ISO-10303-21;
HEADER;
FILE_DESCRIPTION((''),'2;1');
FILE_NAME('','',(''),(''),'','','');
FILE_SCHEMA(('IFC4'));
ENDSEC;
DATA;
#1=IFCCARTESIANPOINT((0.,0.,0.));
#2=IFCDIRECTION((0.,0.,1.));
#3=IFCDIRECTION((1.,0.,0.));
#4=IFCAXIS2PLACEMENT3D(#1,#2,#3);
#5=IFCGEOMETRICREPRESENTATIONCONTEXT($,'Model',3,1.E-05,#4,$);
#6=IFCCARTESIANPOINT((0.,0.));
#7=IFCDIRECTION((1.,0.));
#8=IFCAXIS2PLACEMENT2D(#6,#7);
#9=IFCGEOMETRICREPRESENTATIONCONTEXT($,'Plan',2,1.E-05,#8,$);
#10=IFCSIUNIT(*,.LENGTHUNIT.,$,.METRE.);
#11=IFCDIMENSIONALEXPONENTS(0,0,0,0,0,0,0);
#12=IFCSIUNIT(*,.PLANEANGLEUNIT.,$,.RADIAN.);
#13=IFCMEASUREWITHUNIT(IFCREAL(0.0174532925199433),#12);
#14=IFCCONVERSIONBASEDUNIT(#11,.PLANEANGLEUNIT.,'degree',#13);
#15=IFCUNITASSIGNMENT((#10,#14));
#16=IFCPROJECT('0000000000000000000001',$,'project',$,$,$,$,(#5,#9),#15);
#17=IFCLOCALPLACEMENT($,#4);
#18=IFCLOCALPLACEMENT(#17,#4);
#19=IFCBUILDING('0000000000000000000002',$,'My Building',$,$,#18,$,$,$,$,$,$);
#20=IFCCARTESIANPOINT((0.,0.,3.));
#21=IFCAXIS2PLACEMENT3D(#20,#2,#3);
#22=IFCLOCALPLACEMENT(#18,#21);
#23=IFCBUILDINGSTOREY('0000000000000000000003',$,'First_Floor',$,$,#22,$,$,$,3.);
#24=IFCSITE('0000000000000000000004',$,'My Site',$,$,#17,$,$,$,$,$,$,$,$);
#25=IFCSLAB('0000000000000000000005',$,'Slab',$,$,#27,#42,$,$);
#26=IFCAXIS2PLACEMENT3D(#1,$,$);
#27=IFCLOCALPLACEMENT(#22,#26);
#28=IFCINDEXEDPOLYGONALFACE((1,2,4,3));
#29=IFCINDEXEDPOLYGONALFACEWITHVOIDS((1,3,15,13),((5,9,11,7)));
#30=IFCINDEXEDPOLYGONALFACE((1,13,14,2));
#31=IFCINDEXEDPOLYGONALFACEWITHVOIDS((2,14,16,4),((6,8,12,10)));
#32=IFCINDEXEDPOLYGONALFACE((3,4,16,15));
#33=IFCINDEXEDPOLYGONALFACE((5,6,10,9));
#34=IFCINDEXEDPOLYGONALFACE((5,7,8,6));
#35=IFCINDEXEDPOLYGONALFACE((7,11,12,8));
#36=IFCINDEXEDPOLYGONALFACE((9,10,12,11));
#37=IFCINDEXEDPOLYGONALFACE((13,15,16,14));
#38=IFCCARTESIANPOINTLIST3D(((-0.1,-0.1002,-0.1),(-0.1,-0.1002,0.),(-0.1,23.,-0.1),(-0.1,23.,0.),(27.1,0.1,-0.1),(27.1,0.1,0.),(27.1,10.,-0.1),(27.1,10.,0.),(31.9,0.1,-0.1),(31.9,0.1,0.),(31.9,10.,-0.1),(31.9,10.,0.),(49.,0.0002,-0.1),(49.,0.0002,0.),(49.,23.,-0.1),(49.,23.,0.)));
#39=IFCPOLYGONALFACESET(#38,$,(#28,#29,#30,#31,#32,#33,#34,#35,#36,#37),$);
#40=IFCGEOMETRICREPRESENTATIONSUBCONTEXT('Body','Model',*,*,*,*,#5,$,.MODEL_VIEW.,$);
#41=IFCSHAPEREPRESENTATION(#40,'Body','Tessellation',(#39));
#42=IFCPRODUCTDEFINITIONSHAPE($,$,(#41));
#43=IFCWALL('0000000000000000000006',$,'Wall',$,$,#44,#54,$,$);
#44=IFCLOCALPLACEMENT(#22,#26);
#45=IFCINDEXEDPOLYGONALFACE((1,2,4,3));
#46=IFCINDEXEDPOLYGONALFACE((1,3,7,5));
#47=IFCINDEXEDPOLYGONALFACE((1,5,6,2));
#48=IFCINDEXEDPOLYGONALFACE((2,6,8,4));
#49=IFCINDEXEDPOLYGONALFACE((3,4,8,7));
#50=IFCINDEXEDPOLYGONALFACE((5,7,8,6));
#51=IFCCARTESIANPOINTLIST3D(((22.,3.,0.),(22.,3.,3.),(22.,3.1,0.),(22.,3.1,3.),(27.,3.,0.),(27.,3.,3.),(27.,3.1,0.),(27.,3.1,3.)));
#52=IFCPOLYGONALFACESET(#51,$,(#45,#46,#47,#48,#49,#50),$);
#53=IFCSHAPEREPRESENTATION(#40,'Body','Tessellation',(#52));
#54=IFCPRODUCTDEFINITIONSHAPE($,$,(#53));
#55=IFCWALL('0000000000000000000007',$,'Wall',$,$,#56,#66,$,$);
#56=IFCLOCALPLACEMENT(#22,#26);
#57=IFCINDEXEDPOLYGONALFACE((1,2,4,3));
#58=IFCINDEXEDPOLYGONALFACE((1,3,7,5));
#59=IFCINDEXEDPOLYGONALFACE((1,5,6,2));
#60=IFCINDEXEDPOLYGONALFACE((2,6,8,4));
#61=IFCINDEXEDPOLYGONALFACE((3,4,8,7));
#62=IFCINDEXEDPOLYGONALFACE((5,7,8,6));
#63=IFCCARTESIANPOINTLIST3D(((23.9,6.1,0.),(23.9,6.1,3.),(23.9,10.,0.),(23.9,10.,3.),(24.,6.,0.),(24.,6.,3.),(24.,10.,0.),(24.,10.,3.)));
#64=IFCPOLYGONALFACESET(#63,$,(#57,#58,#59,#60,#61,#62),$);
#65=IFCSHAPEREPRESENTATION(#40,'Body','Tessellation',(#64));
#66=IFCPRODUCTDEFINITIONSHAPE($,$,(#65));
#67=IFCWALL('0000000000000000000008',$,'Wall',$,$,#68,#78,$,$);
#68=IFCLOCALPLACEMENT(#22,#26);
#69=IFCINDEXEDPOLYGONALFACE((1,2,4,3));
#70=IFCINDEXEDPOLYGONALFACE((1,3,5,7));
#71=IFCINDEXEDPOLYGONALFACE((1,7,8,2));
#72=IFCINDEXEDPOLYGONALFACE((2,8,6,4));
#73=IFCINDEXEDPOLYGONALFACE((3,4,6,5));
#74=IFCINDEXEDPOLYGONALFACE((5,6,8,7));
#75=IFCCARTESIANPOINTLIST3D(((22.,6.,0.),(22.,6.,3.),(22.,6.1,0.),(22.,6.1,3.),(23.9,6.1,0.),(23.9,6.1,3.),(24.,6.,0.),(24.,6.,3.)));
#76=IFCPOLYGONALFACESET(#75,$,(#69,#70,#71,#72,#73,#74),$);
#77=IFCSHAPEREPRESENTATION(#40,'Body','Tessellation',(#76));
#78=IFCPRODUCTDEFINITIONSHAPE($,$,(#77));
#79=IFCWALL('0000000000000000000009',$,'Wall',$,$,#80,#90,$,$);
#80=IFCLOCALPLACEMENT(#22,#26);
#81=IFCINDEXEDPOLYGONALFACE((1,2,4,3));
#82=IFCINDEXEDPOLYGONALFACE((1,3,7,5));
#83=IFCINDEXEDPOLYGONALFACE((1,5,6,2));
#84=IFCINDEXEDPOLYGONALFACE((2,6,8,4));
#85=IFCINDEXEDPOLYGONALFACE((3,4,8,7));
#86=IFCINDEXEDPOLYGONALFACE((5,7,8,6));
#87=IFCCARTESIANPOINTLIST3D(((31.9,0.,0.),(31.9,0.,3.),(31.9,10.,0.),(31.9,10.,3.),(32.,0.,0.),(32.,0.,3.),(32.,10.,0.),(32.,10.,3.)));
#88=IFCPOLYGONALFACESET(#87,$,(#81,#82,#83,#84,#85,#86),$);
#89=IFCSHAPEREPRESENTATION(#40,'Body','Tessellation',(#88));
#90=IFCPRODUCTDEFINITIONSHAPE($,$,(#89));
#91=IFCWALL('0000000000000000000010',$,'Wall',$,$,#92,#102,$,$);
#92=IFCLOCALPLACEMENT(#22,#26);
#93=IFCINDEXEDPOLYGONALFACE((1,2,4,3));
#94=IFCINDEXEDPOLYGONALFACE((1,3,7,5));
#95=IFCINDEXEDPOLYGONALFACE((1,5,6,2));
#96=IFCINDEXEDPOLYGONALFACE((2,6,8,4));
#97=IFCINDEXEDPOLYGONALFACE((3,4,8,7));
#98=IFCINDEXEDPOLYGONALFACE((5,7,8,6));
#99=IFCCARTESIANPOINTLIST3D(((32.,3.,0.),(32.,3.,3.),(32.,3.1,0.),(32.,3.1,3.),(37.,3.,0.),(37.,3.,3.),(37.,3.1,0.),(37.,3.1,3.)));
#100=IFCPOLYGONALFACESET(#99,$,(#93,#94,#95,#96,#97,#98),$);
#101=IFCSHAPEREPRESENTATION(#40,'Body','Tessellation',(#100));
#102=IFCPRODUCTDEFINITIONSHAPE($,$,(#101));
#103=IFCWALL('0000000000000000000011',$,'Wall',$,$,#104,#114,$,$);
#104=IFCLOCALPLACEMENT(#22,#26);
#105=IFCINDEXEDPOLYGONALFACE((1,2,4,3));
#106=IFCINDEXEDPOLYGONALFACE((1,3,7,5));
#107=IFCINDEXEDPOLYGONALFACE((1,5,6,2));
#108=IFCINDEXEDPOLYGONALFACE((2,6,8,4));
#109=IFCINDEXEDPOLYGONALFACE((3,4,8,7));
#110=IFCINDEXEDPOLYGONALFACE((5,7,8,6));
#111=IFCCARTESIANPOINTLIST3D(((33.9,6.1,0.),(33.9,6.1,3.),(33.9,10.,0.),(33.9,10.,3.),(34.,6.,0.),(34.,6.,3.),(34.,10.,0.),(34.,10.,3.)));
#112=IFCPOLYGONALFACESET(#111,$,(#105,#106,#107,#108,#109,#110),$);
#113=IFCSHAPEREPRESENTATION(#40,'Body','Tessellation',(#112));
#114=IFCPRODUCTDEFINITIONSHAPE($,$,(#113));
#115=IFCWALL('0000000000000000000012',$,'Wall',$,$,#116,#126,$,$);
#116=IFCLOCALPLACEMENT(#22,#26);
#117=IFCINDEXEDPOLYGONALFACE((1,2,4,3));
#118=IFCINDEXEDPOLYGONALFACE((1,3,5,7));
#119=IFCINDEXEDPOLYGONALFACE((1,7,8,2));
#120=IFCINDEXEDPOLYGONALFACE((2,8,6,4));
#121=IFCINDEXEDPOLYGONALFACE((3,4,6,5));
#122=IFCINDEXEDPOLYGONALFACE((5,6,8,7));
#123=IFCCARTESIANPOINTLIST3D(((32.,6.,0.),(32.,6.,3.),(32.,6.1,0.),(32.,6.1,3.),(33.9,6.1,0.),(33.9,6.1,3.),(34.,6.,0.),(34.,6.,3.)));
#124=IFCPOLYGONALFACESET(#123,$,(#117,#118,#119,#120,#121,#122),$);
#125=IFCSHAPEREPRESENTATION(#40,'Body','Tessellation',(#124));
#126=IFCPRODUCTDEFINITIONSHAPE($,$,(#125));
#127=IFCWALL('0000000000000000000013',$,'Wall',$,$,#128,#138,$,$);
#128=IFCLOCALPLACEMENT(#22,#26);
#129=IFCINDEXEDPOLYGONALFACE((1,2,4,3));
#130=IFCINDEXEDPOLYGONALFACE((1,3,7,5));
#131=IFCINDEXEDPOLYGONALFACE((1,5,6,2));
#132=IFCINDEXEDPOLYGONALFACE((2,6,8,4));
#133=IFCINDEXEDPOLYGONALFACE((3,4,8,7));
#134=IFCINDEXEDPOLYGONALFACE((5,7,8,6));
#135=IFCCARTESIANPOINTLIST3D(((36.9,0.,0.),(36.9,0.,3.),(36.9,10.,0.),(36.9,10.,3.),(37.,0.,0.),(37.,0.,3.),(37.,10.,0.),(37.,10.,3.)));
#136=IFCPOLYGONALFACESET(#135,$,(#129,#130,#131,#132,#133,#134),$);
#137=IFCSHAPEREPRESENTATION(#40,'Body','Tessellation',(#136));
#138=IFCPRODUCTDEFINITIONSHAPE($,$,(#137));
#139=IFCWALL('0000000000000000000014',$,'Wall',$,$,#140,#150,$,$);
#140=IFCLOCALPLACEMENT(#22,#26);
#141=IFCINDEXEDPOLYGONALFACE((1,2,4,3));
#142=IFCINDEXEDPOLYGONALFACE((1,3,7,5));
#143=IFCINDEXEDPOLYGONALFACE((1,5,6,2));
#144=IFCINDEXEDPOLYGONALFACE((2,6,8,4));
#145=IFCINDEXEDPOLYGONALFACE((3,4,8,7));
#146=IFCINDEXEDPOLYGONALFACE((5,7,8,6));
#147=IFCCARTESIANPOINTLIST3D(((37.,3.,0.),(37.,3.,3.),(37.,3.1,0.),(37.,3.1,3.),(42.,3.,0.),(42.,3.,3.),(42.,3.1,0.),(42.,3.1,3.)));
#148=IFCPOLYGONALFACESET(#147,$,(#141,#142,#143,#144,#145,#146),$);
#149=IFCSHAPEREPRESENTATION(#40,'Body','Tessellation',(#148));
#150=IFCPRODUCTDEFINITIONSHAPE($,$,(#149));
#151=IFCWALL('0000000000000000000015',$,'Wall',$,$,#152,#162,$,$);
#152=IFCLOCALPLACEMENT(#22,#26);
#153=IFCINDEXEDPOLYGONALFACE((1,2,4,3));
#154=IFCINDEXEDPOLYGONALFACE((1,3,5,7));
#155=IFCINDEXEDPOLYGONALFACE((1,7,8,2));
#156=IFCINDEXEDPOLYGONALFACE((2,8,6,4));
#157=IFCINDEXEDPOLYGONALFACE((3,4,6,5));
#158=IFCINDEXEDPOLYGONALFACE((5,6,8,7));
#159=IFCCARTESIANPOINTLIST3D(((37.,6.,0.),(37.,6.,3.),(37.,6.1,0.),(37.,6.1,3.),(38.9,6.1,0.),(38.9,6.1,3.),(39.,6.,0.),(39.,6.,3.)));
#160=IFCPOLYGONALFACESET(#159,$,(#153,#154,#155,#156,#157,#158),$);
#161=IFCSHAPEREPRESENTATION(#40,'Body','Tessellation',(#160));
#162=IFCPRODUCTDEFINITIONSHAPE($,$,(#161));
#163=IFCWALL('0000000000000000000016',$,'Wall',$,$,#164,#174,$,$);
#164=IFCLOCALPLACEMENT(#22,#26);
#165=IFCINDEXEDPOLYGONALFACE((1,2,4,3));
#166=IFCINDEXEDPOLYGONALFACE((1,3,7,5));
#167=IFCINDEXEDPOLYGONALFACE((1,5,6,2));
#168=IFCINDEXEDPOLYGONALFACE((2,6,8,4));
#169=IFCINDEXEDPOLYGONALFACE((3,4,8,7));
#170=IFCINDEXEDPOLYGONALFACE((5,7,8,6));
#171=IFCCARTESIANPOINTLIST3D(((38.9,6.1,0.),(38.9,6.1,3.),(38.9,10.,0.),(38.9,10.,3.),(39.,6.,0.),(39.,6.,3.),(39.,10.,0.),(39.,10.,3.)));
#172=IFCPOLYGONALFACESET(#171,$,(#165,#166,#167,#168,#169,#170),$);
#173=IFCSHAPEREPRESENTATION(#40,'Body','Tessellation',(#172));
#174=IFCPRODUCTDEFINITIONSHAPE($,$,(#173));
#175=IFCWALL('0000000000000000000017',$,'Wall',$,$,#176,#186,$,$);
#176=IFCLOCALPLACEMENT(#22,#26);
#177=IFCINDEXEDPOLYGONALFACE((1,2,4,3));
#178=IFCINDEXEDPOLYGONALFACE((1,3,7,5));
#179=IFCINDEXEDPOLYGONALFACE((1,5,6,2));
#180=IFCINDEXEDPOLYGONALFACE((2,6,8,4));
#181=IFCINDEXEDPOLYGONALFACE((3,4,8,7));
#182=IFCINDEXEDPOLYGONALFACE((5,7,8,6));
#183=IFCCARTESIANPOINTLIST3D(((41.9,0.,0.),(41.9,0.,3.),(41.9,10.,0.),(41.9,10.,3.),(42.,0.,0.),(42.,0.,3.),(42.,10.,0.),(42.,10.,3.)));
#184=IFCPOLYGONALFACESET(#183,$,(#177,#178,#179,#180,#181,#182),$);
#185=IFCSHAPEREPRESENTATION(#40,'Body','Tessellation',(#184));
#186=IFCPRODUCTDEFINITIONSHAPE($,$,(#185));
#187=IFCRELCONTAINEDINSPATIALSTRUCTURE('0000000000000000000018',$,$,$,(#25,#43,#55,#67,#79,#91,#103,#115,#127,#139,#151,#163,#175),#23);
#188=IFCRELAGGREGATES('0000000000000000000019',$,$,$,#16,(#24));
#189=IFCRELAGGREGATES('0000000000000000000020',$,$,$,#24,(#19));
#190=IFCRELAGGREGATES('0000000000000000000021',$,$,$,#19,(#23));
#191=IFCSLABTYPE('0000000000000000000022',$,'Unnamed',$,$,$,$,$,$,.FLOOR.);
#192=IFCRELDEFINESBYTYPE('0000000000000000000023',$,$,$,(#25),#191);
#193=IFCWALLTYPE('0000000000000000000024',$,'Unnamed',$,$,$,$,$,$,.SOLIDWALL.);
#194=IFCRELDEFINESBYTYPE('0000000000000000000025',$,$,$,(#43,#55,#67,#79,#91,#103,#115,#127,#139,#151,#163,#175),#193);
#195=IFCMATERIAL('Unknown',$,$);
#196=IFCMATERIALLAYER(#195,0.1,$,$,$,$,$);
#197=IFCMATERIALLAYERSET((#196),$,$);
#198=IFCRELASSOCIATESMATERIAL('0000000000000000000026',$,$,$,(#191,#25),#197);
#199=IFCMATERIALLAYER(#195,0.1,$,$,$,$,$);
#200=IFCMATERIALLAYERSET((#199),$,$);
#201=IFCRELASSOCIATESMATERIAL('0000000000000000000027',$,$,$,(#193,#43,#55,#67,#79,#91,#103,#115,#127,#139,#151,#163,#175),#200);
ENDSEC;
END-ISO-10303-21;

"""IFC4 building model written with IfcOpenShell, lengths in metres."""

from ifc_helpers import new_model, entity, si_unit, converted_unit, frame, frame_2d, origin_with_axes, origin_2d_with_axis, place, context, subcontext, project, spatial, line, indexed_curve, rectangle, outline, extrude, material, layer, layer_set, layer_usage, type_object, element, save


model = new_model("IFC4")

# Units and contexts
model_context = context("Model", 3, precision=1e-05, world=origin_with_axes())
plan_context = context("Plan", 2, precision=1e-05, world=origin_2d_with_axis())
body_context = subcontext(model_context, "Body", "Model", "MODEL_VIEW")
ifc_project = project(units=[si_unit("LENGTHUNIT", "METRE"), converted_unit("PLANEANGLEUNIT", "degree", entity("IfcReal", 0.0174532925199433), si_unit("PLANEANGLEUNIT", "RADIAN"), dimensions=[0, 0, 0, 0, 0, 0, 0])], contexts=[model_context, plan_context])

# Site, building, storey
site_placement = place(None, origin_with_axes())
site = spatial("IfcSite", under=ifc_project, at=site_placement, Name="My Site")
building_placement = place(site_placement, origin_with_axes())
building = spatial("IfcBuilding", under=site, at=building_placement, Name="My Building")
storey_placement = place(building_placement, frame((0.0, 0.0, 3.0), z_axis=(0.0, 0.0, 1.0), x_axis=(1.0, 0.0, 0.0)))
storey = spatial("IfcBuildingStorey", under=building, at=storey_placement, Name="First_Floor", Elevation=3.0)

# Slab, opening
ifc_material = material(Name="Unknown")
ifc_layer_1 = layer(ifc_material, 0.1)
ifc_layer_set_1 = layer_set([ifc_layer_1])
ifc_layer_usage_1 = layer_usage(ifc_layer_set_1, "AXIS3", "POSITIVE", -0.1)
slab_type = type_object("IfcSlabType", Name="Unnamed", PredefinedType="FLOOR", material=ifc_layer_set_1)
slab_placement = place(storey_placement, frame((49.0, 0.0002, 0.0), z_axis=(0.0, 0.0, 1.0), x_axis=(1.0, 0.0, 0.0)))
slab = element("IfcSlab", 1, at=slab_placement, inside=storey, type_object=slab_type, material=ifc_layer_usage_1, Name="Slab", context=body_context, shape_type="SweptSolid", body=[
    extrude(outline(indexed_curve([(0.0, 0.0), (0.0, 22.9998), (-49.1, 22.9998), (-49.1, -0.1004), (0.0, 0.0)])), frame((0.0, 0.0, -0.1), z_axis=(0.0, 0.0, 1.0), x_axis=(1.0, 0.0, 0.0)), (0.0, 0.0, 1.0), 0.1),
])
opening_placement = place(slab_placement, frame((-49.0, -0.0002, 0.0), z_axis=(0.0, 0.0, 1.0), x_axis=(1.0, 0.0, 0.0)))
element("IfcOpeningElement", 2, at=opening_placement, cuts=slab, context=body_context, shape_type="SweptSolid", body=[
    extrude(rectangle(XDim=4.8, YDim=9.9, at=frame_2d((29.5, 5.05))), frame((0.0, 0.0, -0.25)), (0.0, 0.0, 1.0), 0.4),
])

# Walls
ifc_layer_2 = layer(ifc_material, 0.1)
ifc_layer_set_2 = layer_set([ifc_layer_2])
ifc_layer_usage_2 = layer_usage(ifc_layer_set_2, "AXIS2", "POSITIVE", 0.0)
wall_type = type_object("IfcWallType", Name="Unnamed", PredefinedType="SOLIDWALL", material=ifc_layer_set_2)
wall_1_placement = place(storey_placement, frame((22.0, 3.0, 0.0), z_axis=(0.0, 0.0, 1.0), x_axis=(1.0, 0.0, 0.0)))
element("IfcWall", 3, at=wall_1_placement, inside=storey, type_object=wall_type, material=ifc_layer_usage_2, Name="Wall", context=body_context, shape_type="SweptSolid", body=[
    extrude(outline(indexed_curve([(0.0, 0.0), (0.0, 0.1), (5.0, 0.1), (5.0, 0.0)], segments=[line(1, 2, 3, 4, 1)])), origin_with_axes(), (0.0, 0.0, 1.0), 3.0),
])
ifc_layer_usage_3 = layer_usage(ifc_layer_set_2, "AXIS2", "POSITIVE", 0.0)
wall_2_placement = place(storey_placement, frame((24.0, 6.0, 0.0), z_axis=(0.0, 0.0, 1.0), x_axis=(0.0, 1.0, 0.0)))
element("IfcWall", 4, at=wall_2_placement, inside=storey, type_object=wall_type, material=ifc_layer_usage_3, Name="Wall", context=body_context, shape_type="SweptSolid", body=[
    extrude(outline(indexed_curve([(0.0, 0.0), (0.1, 0.1), (4.0, 0.1), (4.0, 0.0)], segments=[line(1, 2, 3, 4, 1)])), origin_with_axes(), (0.0, 0.0, 1.0), 3.0),
])
ifc_layer_usage_4 = layer_usage(ifc_layer_set_2, "AXIS2", "POSITIVE", 0.0)
wall_3_placement = place(storey_placement, frame((22.0, 6.0, 0.0), z_axis=(0.0, 0.0, 1.0), x_axis=(1.0, 0.0, 0.0)))
element("IfcWall", 5, at=wall_3_placement, inside=storey, type_object=wall_type, material=ifc_layer_usage_4, Name="Wall", context=body_context, shape_type="SweptSolid", body=[
    extrude(outline(indexed_curve([(0.0, 0.0), (0.0, 0.1), (1.9, 0.1), (2.0, 0.0)], segments=[line(1, 2, 3, 4, 1)])), origin_with_axes(), (0.0, 0.0, 1.0), 3.0),
])
ifc_layer_usage_5 = layer_usage(ifc_layer_set_2, "AXIS2", "POSITIVE", 0.0)
wall_4_placement = place(storey_placement, frame((31.9, 10.0, 0.0), z_axis=(0.0, 0.0, 1.0), x_axis=(0.0, -1.0, 0.0)))
element("IfcWall", 6, at=wall_4_placement, inside=storey, type_object=wall_type, material=ifc_layer_usage_5, Name="Wall", context=body_context, shape_type="SweptSolid", body=[
    extrude(outline(indexed_curve([(0.0, 0.0), (0.0, 0.1), (10.0, 0.1), (10.0, 0.0)], segments=[line(1, 2, 3, 4, 1)])), origin_with_axes(), (0.0, 0.0, 1.0), 3.0),
])
ifc_layer_usage_6 = layer_usage(ifc_layer_set_2, "AXIS2", "POSITIVE", 0.0)
wall_5_placement = place(storey_placement, frame((32.0, 3.0, 0.0), z_axis=(0.0, 0.0, 1.0), x_axis=(1.0, 0.0, 0.0)))
element("IfcWall", 7, at=wall_5_placement, inside=storey, type_object=wall_type, material=ifc_layer_usage_6, Name="Wall", context=body_context, shape_type="SweptSolid", body=[
    extrude(outline(indexed_curve([(0.0, 0.0), (0.0, 0.1), (5.0, 0.1), (5.0, 0.0)], segments=[line(1, 2, 3, 4, 1)])), origin_with_axes(), (0.0, 0.0, 1.0), 3.0),
])
ifc_layer_usage_7 = layer_usage(ifc_layer_set_2, "AXIS2", "POSITIVE", 0.0)
wall_6_placement = place(storey_placement, frame((34.0, 6.0, 0.0), z_axis=(0.0, 0.0, 1.0), x_axis=(0.0, 1.0, 0.0)))
element("IfcWall", 8, at=wall_6_placement, inside=storey, type_object=wall_type, material=ifc_layer_usage_7, Name="Wall", context=body_context, shape_type="SweptSolid", body=[
    extrude(outline(indexed_curve([(0.0, 0.0), (0.1, 0.1), (4.0, 0.1), (4.0, 0.0)], segments=[line(1, 2, 3, 4, 1)])), origin_with_axes(), (0.0, 0.0, 1.0), 3.0),
])
ifc_layer_usage_8 = layer_usage(ifc_layer_set_2, "AXIS2", "POSITIVE", 0.0)
wall_7_placement = place(storey_placement, frame((32.0, 6.0, 0.0), z_axis=(0.0, 0.0, 1.0), x_axis=(1.0, 0.0, 0.0)))
element("IfcWall", 9, at=wall_7_placement, inside=storey, type_object=wall_type, material=ifc_layer_usage_8, Name="Wall", context=body_context, shape_type="SweptSolid", body=[
    extrude(outline(indexed_curve([(0.0, 0.0), (0.0, 0.1), (1.9, 0.1), (2.0, 0.0)], segments=[line(1, 2, 3, 4, 1)])), origin_with_axes(), (0.0, 0.0, 1.0), 3.0),
])
ifc_layer_usage_9 = layer_usage(ifc_layer_set_2, "AXIS2", "POSITIVE", 0.0)
wall_8_placement = place(storey_placement, frame((36.9, 10.0, 0.0), z_axis=(0.0, 0.0, 1.0), x_axis=(0.0, -1.0, 0.0)))
element("IfcWall", 10, at=wall_8_placement, inside=storey, type_object=wall_type, material=ifc_layer_usage_9, Name="Wall", context=body_context, shape_type="SweptSolid", body=[
    extrude(outline(indexed_curve([(0.0, 0.0), (0.0, 0.1), (10.0, 0.1), (10.0, 0.0)], segments=[line(1, 2, 3, 4, 1)])), origin_with_axes(), (0.0, 0.0, 1.0), 3.0),
])
ifc_layer_usage_10 = layer_usage(ifc_layer_set_2, "AXIS2", "POSITIVE", 0.0)
wall_9_placement = place(storey_placement, frame((37.0, 3.0, 0.0), z_axis=(0.0, 0.0, 1.0), x_axis=(1.0, 0.0, 0.0)))
element("IfcWall", 11, at=wall_9_placement, inside=storey, type_object=wall_type, material=ifc_layer_usage_10, Name="Wall", context=body_context, shape_type="SweptSolid", body=[
    extrude(outline(indexed_curve([(0.0, 0.0), (0.0, 0.1), (5.0, 0.1), (5.0, 0.0)], segments=[line(1, 2, 3, 4, 1)])), origin_with_axes(), (0.0, 0.0, 1.0), 3.0),
])
ifc_layer_usage_11 = layer_usage(ifc_layer_set_2, "AXIS2", "POSITIVE", 0.0)
wall_10_placement = place(storey_placement, frame((37.0, 6.0, 0.0), z_axis=(0.0, 0.0, 1.0), x_axis=(1.0, 0.0, 0.0)))
element("IfcWall", 12, at=wall_10_placement, inside=storey, type_object=wall_type, material=ifc_layer_usage_11, Name="Wall", context=body_context, shape_type="SweptSolid", body=[
    extrude(outline(indexed_curve([(0.0, 0.0), (0.0, 0.1), (1.9, 0.1), (2.0, 0.0)], segments=[line(1, 2, 3, 4, 1)])), origin_with_axes(), (0.0, 0.0, 1.0), 3.0),
])
ifc_layer_usage_12 = layer_usage(ifc_layer_set_2, "AXIS2", "POSITIVE", 0.0)
wall_11_placement = place(storey_placement, frame((39.0, 6.0, 0.0), z_axis=(0.0, 0.0, 1.0), x_axis=(0.0, 1.0, 0.0)))
element("IfcWall", 13, at=wall_11_placement, inside=storey, type_object=wall_type, material=ifc_layer_usage_12, Name="Wall", context=body_context, shape_type="SweptSolid", body=[
    extrude(outline(indexed_curve([(0.0, 0.0), (0.1, 0.1), (4.0, 0.1), (4.0, 0.0)], segments=[line(1, 2, 3, 4, 1)])), origin_with_axes(), (0.0, 0.0, 1.0), 3.0),
])
ifc_layer_usage_13 = layer_usage(ifc_layer_set_2, "AXIS2", "POSITIVE", 0.0)
wall_12_placement = place(storey_placement, frame((41.9, 10.0, 0.0), z_axis=(0.0, 0.0, 1.0), x_axis=(0.0, -1.0, 0.0)))
element("IfcWall", 14, at=wall_12_placement, inside=storey, type_object=wall_type, material=ifc_layer_usage_13, Name="Wall", context=body_context, shape_type="SweptSolid", body=[
    extrude(outline(indexed_curve([(0.0, 0.0), (0.0, 0.1), (10.0, 0.1), (10.0, 0.0)], segments=[line(1, 2, 3, 4, 1)])), origin_with_axes(), (0.0, 0.0, 1.0), 3.0),
])

save(model, "model.ifc")
